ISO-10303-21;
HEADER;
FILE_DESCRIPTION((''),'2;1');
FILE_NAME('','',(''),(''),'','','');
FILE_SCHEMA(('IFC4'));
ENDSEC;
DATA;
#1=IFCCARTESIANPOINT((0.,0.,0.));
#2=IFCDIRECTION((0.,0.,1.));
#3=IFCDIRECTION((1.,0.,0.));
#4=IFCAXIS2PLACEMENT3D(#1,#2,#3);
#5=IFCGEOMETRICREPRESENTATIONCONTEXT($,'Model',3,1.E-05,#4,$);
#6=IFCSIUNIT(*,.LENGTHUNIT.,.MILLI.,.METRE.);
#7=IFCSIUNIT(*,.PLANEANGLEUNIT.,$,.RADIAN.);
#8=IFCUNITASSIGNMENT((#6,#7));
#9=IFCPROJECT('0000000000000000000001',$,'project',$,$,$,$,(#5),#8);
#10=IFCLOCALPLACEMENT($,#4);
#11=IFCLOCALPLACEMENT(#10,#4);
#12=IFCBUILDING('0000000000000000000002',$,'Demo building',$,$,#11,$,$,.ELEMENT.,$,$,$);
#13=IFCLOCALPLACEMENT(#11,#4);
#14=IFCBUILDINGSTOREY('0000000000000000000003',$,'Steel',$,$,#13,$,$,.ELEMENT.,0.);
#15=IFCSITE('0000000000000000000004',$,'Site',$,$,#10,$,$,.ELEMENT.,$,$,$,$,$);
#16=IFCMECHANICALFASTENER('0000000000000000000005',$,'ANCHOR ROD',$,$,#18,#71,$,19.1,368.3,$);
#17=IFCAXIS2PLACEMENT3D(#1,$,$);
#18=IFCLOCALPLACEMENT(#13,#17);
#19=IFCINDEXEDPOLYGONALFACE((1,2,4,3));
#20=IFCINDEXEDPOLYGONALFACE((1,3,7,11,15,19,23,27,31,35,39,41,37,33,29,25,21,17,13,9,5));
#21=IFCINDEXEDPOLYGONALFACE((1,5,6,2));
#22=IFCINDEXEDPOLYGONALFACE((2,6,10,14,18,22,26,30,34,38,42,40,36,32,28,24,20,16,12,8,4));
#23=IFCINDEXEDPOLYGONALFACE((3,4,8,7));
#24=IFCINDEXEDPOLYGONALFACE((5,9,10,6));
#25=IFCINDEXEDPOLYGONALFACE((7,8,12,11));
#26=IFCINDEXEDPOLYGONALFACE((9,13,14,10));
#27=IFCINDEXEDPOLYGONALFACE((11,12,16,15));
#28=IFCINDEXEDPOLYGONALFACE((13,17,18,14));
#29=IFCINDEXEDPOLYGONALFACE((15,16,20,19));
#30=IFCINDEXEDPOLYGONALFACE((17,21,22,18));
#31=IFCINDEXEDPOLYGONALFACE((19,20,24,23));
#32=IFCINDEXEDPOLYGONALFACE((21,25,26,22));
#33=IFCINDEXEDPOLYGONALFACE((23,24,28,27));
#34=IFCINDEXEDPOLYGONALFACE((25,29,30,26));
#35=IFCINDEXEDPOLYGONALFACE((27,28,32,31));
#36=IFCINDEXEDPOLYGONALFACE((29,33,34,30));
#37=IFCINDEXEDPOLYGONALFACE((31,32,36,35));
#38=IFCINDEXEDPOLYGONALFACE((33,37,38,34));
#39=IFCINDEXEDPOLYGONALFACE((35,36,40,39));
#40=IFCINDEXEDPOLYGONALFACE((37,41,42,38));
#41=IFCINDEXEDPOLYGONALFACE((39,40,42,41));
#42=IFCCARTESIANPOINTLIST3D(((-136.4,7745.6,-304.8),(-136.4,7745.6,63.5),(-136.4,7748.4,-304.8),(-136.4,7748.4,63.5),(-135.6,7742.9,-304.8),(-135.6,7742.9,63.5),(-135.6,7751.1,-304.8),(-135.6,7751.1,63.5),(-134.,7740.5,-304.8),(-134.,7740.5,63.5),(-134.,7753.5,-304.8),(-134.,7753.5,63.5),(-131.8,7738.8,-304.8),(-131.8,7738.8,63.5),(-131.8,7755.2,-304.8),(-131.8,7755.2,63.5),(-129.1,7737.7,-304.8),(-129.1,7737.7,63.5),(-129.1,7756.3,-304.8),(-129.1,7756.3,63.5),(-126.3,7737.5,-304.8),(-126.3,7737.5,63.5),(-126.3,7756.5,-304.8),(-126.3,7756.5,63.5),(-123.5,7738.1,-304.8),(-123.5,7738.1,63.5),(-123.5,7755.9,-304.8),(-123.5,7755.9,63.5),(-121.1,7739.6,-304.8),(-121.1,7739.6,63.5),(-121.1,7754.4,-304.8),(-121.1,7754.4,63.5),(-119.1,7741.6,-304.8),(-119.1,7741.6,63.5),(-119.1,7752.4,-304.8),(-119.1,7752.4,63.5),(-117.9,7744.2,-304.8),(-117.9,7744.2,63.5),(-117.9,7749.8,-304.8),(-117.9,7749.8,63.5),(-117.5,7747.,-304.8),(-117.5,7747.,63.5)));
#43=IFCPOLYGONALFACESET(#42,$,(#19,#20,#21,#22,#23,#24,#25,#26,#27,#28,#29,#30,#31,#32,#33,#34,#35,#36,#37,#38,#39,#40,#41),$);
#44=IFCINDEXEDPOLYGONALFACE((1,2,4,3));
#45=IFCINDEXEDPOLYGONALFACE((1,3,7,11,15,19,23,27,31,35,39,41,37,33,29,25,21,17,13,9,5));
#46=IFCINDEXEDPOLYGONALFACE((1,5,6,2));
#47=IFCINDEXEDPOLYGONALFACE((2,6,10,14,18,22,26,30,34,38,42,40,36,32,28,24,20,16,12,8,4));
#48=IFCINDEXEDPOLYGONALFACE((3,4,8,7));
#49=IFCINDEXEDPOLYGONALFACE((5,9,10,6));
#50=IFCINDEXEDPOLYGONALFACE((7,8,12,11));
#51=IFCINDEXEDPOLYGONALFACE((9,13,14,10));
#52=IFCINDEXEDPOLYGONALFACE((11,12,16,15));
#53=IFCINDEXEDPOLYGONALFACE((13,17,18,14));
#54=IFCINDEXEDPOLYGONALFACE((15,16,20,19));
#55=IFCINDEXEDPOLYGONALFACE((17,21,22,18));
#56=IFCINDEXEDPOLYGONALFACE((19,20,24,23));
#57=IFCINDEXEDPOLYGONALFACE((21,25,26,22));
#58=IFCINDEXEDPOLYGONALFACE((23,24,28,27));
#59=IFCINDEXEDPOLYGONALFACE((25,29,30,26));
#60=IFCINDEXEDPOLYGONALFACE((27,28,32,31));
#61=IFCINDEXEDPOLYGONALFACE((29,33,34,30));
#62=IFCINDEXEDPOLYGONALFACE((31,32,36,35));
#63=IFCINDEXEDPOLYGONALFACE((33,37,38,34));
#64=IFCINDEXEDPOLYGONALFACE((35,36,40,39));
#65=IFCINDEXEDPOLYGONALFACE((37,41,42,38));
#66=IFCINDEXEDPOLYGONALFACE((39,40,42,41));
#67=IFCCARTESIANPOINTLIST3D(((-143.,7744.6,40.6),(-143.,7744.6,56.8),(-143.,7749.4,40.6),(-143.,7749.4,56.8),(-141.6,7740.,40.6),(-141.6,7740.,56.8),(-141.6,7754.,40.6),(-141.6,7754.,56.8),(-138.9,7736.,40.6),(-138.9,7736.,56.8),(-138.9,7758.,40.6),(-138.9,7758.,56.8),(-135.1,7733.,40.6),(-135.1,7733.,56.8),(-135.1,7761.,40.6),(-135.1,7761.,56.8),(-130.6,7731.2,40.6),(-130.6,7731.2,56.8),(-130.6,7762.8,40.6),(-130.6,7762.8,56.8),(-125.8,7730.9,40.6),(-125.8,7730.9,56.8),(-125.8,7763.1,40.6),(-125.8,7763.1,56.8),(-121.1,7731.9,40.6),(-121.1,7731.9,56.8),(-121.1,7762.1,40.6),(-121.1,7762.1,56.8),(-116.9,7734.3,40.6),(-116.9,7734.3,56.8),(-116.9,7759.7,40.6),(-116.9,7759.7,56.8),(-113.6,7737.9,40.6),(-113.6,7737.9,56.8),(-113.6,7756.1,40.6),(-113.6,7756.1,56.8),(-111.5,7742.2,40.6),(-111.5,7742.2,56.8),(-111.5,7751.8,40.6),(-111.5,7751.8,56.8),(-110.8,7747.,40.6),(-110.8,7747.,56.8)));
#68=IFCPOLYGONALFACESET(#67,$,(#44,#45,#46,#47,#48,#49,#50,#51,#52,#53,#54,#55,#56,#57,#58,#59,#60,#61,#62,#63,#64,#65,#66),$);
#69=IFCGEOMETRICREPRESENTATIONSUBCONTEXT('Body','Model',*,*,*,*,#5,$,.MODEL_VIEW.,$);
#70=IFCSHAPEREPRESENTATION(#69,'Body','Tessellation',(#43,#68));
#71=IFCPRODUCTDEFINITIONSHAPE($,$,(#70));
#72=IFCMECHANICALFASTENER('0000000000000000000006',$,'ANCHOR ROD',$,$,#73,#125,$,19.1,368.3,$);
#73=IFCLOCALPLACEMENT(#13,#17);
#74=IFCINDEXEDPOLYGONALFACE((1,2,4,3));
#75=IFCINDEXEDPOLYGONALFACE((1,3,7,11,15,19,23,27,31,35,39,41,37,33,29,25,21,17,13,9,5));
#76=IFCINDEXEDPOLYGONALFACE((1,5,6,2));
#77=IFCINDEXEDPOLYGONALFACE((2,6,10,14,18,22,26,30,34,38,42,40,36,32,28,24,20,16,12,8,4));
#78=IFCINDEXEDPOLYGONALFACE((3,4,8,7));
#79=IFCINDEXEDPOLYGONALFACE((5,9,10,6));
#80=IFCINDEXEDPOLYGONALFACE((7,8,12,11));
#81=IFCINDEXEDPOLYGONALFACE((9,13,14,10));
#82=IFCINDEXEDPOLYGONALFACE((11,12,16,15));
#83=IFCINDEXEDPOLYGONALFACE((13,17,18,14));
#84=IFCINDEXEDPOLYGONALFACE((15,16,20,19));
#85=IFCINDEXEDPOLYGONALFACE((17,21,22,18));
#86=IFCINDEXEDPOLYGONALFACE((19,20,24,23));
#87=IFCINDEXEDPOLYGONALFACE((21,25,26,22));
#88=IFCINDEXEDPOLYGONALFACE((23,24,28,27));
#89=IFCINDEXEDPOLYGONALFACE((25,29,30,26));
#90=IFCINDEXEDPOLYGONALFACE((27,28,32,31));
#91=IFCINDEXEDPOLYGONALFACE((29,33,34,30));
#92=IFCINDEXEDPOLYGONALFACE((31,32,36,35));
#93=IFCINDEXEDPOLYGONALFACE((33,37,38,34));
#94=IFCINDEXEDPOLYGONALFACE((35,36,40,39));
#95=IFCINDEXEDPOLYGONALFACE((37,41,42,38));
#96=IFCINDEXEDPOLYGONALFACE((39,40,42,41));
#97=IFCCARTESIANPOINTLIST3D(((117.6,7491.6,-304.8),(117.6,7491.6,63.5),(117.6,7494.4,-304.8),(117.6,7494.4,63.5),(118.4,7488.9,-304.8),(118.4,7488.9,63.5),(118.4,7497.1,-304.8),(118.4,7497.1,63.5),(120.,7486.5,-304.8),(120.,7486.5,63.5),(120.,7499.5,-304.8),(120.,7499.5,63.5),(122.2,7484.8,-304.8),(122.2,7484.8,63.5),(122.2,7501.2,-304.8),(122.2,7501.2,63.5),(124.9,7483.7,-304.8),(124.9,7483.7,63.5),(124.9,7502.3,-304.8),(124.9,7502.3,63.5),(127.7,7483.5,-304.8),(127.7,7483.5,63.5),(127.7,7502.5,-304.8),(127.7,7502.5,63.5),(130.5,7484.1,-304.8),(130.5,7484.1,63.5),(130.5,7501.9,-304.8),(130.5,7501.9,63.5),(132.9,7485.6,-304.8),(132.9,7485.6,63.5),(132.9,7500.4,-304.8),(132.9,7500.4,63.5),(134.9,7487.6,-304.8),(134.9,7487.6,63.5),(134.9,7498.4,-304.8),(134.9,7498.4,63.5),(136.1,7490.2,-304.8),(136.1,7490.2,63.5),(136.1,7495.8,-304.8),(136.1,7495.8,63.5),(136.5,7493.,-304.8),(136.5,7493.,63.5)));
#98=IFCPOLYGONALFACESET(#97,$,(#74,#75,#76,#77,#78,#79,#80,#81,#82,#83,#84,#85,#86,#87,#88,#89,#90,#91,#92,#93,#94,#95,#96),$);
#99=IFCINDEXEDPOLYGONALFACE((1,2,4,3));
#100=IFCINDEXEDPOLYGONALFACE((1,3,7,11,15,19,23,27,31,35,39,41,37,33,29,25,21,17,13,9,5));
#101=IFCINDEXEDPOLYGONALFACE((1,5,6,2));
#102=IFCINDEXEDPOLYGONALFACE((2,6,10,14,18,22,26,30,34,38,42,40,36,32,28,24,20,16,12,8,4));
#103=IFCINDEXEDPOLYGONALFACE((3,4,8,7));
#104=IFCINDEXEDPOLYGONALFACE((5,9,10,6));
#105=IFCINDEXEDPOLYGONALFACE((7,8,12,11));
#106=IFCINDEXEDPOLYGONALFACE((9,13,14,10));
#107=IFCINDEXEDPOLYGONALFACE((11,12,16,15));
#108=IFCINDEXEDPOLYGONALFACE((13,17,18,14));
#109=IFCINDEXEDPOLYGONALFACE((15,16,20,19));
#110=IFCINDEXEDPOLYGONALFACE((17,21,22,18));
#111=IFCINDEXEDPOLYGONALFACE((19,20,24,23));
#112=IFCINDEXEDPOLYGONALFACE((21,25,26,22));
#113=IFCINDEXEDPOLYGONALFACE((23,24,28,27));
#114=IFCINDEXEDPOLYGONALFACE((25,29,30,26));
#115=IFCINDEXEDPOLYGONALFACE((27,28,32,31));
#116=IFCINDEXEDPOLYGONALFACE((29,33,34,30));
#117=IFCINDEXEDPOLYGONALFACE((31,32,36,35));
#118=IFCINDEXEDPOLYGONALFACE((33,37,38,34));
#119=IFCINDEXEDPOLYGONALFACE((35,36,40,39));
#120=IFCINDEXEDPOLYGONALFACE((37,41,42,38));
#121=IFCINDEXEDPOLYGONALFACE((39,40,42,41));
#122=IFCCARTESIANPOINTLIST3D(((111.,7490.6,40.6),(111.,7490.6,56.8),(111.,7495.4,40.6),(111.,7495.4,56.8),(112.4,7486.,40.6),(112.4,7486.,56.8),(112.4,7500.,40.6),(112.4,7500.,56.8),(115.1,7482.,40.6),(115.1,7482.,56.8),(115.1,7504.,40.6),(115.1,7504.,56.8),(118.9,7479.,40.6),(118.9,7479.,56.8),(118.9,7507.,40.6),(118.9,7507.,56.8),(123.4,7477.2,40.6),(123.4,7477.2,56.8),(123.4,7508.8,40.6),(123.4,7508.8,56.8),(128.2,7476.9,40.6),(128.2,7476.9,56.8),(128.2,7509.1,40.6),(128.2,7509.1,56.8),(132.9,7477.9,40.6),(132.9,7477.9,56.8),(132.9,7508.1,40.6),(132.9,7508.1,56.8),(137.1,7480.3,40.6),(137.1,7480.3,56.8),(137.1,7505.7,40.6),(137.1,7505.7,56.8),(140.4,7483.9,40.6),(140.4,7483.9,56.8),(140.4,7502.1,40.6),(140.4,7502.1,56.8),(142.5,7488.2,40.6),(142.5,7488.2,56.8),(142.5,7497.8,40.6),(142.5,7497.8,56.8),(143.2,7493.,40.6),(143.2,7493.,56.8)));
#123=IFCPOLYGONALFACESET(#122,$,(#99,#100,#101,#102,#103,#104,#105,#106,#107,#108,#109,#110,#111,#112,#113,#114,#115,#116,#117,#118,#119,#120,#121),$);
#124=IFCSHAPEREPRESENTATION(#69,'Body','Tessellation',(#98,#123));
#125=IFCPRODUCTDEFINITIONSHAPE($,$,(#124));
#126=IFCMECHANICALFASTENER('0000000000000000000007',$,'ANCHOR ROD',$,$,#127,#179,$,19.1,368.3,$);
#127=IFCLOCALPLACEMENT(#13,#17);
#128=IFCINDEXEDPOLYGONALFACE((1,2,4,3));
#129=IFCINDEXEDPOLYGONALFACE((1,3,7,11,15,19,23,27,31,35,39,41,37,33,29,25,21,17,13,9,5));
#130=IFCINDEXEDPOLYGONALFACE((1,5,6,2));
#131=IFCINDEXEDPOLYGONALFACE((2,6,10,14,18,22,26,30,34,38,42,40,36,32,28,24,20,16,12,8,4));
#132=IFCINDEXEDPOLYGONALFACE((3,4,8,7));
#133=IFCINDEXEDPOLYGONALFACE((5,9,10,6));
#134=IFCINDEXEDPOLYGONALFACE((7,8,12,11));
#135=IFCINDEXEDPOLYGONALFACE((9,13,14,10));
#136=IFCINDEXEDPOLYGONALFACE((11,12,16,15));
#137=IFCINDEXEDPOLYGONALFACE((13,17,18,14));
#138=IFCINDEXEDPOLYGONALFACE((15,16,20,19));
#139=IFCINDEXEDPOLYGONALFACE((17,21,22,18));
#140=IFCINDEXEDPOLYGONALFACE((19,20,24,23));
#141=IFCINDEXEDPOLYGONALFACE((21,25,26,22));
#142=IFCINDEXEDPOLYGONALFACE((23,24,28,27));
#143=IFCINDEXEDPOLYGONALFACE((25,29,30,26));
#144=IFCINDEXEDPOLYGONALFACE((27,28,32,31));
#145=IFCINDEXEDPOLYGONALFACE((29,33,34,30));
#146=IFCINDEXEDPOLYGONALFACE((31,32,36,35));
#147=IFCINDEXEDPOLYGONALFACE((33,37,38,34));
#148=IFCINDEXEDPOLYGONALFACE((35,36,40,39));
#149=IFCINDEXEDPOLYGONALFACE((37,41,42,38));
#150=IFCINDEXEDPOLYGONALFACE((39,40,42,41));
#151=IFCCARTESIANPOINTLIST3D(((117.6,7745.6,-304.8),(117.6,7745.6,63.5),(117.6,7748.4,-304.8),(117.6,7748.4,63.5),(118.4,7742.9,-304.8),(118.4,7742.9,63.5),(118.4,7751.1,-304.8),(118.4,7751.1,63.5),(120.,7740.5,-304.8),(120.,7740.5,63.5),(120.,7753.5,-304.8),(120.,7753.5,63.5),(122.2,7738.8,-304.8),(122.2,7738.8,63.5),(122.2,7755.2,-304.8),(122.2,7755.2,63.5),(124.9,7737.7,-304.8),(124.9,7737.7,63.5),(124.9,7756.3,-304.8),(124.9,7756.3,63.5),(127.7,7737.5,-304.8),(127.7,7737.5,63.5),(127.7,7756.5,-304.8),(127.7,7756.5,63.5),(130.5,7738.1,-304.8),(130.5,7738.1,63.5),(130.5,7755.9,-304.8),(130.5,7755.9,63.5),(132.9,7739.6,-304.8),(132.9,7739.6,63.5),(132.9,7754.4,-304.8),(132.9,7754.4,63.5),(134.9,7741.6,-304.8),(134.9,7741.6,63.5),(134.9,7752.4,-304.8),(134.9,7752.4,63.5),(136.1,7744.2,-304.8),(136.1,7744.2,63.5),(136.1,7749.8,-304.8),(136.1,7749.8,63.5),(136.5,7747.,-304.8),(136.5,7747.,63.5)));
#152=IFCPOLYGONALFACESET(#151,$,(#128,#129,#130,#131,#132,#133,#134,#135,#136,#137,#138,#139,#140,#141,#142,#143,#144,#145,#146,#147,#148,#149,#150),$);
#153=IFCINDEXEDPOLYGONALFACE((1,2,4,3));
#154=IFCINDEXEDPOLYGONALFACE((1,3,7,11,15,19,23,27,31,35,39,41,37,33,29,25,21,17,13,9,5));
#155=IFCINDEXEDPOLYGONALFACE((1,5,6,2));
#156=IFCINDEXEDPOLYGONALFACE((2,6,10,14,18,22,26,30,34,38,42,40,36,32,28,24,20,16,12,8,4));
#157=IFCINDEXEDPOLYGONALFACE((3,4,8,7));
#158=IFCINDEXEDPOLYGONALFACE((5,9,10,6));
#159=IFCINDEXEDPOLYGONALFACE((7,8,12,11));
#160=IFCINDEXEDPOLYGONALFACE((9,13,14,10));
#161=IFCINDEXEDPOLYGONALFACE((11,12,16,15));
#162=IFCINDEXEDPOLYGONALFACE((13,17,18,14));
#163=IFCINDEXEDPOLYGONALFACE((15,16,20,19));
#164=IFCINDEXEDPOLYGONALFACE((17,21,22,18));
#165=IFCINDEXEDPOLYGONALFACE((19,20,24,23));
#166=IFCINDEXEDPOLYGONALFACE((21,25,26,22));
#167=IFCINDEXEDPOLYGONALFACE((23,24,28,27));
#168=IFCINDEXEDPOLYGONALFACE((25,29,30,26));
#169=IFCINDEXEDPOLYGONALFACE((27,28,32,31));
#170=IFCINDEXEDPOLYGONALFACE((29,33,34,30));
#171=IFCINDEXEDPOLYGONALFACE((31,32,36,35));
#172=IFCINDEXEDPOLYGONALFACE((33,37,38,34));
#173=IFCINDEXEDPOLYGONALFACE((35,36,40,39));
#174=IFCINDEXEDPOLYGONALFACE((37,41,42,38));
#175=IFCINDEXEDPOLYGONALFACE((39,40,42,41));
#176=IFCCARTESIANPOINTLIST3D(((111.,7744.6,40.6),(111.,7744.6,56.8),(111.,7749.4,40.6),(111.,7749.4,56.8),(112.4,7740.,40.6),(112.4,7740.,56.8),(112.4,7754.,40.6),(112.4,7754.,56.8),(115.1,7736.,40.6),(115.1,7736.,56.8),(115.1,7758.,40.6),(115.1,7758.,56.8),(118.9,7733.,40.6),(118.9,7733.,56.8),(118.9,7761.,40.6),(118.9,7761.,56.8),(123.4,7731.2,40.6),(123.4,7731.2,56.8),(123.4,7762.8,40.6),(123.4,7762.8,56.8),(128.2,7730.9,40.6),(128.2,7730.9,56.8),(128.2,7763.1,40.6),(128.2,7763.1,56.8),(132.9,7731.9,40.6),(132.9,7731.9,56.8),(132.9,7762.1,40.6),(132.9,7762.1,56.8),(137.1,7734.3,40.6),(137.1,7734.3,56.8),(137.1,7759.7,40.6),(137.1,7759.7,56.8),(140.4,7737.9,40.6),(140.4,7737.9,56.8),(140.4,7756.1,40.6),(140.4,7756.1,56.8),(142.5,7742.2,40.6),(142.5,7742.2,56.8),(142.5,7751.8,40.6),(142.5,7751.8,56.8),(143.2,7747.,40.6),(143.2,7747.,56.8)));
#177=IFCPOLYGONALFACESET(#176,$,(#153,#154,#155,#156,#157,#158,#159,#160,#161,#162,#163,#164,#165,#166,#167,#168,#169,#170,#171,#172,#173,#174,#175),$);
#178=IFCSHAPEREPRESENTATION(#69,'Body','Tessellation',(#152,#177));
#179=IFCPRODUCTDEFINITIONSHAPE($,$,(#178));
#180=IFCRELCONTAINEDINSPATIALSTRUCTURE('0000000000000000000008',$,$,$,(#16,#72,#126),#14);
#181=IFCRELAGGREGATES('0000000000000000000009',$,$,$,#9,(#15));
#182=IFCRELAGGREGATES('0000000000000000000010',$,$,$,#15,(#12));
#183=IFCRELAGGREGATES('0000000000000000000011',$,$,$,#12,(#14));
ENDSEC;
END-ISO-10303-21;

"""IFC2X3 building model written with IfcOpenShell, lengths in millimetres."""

from ifc_helpers import new_model, si_unit, frame, origin, origin_with_axes, origin_2d, place, context, subcontext, project, spatial, circle, extrude, element, save


model = new_model("IFC2X3")

# Units and contexts
model_context = context("Model", 3, precision=1e-05, world=origin_with_axes())
body_context = subcontext(model_context, "Body", "Model", "MODEL_VIEW")
ifc_project = project(units=[si_unit("LENGTHUNIT", "METRE", prefix="MILLI"), si_unit("PLANEANGLEUNIT", "RADIAN")], contexts=[model_context])

# Site, building, storey
site_placement = place(None, origin_with_axes())
site = spatial("IfcSite", under=ifc_project, at=site_placement, Name="Site", CompositionType="ELEMENT")
building_placement = place(site_placement, origin_with_axes())
building = spatial("IfcBuilding", under=site, at=building_placement, Name="Demo building", CompositionType="ELEMENT")
placement = place(building_placement, origin_with_axes())
storey = spatial("IfcBuildingStorey", under=building, at=placement, Name="Steel", CompositionType="ELEMENT", Elevation=0.0)

# Mechanical fasteners
for number, where, z_axis, x_axis, name in (
    (1, (-127.0, 7747.0, -304.8), (0.0, 0.0, 1.0), (1.0, 0.0, 0.0), "ANCHOR ROD"),
    (2, (127.0, 7493.0, -304.8), (0.0, 0.0, 1.0), (1.0, 0.0, 0.0), "ANCHOR ROD"),
    (3, (127.0, 7747.0, -304.8), (0.0, 0.0, 1.0), (1.0, 0.0, 0.0), "ANCHOR ROD"),
):
    element("IfcMechanicalFastener", number, at=place(placement, frame(where, z_axis=z_axis, x_axis=x_axis)), inside=storey, Name=name, NominalDiameter=19.1, NominalLength=368.3, context=body_context, shape_type="SweptSolid", body=[
        extrude(circle(Radius=9.5, at=origin_2d()), origin(), (0.0, 0.0, 1.0), 368.3),
        extrude(circle(Radius=16.2, at=origin_2d()), frame((0.0, 0.0, 345.4)), (0.0, 0.0, 1.0), 16.2),
    ])

save(model, "model.ifc")
